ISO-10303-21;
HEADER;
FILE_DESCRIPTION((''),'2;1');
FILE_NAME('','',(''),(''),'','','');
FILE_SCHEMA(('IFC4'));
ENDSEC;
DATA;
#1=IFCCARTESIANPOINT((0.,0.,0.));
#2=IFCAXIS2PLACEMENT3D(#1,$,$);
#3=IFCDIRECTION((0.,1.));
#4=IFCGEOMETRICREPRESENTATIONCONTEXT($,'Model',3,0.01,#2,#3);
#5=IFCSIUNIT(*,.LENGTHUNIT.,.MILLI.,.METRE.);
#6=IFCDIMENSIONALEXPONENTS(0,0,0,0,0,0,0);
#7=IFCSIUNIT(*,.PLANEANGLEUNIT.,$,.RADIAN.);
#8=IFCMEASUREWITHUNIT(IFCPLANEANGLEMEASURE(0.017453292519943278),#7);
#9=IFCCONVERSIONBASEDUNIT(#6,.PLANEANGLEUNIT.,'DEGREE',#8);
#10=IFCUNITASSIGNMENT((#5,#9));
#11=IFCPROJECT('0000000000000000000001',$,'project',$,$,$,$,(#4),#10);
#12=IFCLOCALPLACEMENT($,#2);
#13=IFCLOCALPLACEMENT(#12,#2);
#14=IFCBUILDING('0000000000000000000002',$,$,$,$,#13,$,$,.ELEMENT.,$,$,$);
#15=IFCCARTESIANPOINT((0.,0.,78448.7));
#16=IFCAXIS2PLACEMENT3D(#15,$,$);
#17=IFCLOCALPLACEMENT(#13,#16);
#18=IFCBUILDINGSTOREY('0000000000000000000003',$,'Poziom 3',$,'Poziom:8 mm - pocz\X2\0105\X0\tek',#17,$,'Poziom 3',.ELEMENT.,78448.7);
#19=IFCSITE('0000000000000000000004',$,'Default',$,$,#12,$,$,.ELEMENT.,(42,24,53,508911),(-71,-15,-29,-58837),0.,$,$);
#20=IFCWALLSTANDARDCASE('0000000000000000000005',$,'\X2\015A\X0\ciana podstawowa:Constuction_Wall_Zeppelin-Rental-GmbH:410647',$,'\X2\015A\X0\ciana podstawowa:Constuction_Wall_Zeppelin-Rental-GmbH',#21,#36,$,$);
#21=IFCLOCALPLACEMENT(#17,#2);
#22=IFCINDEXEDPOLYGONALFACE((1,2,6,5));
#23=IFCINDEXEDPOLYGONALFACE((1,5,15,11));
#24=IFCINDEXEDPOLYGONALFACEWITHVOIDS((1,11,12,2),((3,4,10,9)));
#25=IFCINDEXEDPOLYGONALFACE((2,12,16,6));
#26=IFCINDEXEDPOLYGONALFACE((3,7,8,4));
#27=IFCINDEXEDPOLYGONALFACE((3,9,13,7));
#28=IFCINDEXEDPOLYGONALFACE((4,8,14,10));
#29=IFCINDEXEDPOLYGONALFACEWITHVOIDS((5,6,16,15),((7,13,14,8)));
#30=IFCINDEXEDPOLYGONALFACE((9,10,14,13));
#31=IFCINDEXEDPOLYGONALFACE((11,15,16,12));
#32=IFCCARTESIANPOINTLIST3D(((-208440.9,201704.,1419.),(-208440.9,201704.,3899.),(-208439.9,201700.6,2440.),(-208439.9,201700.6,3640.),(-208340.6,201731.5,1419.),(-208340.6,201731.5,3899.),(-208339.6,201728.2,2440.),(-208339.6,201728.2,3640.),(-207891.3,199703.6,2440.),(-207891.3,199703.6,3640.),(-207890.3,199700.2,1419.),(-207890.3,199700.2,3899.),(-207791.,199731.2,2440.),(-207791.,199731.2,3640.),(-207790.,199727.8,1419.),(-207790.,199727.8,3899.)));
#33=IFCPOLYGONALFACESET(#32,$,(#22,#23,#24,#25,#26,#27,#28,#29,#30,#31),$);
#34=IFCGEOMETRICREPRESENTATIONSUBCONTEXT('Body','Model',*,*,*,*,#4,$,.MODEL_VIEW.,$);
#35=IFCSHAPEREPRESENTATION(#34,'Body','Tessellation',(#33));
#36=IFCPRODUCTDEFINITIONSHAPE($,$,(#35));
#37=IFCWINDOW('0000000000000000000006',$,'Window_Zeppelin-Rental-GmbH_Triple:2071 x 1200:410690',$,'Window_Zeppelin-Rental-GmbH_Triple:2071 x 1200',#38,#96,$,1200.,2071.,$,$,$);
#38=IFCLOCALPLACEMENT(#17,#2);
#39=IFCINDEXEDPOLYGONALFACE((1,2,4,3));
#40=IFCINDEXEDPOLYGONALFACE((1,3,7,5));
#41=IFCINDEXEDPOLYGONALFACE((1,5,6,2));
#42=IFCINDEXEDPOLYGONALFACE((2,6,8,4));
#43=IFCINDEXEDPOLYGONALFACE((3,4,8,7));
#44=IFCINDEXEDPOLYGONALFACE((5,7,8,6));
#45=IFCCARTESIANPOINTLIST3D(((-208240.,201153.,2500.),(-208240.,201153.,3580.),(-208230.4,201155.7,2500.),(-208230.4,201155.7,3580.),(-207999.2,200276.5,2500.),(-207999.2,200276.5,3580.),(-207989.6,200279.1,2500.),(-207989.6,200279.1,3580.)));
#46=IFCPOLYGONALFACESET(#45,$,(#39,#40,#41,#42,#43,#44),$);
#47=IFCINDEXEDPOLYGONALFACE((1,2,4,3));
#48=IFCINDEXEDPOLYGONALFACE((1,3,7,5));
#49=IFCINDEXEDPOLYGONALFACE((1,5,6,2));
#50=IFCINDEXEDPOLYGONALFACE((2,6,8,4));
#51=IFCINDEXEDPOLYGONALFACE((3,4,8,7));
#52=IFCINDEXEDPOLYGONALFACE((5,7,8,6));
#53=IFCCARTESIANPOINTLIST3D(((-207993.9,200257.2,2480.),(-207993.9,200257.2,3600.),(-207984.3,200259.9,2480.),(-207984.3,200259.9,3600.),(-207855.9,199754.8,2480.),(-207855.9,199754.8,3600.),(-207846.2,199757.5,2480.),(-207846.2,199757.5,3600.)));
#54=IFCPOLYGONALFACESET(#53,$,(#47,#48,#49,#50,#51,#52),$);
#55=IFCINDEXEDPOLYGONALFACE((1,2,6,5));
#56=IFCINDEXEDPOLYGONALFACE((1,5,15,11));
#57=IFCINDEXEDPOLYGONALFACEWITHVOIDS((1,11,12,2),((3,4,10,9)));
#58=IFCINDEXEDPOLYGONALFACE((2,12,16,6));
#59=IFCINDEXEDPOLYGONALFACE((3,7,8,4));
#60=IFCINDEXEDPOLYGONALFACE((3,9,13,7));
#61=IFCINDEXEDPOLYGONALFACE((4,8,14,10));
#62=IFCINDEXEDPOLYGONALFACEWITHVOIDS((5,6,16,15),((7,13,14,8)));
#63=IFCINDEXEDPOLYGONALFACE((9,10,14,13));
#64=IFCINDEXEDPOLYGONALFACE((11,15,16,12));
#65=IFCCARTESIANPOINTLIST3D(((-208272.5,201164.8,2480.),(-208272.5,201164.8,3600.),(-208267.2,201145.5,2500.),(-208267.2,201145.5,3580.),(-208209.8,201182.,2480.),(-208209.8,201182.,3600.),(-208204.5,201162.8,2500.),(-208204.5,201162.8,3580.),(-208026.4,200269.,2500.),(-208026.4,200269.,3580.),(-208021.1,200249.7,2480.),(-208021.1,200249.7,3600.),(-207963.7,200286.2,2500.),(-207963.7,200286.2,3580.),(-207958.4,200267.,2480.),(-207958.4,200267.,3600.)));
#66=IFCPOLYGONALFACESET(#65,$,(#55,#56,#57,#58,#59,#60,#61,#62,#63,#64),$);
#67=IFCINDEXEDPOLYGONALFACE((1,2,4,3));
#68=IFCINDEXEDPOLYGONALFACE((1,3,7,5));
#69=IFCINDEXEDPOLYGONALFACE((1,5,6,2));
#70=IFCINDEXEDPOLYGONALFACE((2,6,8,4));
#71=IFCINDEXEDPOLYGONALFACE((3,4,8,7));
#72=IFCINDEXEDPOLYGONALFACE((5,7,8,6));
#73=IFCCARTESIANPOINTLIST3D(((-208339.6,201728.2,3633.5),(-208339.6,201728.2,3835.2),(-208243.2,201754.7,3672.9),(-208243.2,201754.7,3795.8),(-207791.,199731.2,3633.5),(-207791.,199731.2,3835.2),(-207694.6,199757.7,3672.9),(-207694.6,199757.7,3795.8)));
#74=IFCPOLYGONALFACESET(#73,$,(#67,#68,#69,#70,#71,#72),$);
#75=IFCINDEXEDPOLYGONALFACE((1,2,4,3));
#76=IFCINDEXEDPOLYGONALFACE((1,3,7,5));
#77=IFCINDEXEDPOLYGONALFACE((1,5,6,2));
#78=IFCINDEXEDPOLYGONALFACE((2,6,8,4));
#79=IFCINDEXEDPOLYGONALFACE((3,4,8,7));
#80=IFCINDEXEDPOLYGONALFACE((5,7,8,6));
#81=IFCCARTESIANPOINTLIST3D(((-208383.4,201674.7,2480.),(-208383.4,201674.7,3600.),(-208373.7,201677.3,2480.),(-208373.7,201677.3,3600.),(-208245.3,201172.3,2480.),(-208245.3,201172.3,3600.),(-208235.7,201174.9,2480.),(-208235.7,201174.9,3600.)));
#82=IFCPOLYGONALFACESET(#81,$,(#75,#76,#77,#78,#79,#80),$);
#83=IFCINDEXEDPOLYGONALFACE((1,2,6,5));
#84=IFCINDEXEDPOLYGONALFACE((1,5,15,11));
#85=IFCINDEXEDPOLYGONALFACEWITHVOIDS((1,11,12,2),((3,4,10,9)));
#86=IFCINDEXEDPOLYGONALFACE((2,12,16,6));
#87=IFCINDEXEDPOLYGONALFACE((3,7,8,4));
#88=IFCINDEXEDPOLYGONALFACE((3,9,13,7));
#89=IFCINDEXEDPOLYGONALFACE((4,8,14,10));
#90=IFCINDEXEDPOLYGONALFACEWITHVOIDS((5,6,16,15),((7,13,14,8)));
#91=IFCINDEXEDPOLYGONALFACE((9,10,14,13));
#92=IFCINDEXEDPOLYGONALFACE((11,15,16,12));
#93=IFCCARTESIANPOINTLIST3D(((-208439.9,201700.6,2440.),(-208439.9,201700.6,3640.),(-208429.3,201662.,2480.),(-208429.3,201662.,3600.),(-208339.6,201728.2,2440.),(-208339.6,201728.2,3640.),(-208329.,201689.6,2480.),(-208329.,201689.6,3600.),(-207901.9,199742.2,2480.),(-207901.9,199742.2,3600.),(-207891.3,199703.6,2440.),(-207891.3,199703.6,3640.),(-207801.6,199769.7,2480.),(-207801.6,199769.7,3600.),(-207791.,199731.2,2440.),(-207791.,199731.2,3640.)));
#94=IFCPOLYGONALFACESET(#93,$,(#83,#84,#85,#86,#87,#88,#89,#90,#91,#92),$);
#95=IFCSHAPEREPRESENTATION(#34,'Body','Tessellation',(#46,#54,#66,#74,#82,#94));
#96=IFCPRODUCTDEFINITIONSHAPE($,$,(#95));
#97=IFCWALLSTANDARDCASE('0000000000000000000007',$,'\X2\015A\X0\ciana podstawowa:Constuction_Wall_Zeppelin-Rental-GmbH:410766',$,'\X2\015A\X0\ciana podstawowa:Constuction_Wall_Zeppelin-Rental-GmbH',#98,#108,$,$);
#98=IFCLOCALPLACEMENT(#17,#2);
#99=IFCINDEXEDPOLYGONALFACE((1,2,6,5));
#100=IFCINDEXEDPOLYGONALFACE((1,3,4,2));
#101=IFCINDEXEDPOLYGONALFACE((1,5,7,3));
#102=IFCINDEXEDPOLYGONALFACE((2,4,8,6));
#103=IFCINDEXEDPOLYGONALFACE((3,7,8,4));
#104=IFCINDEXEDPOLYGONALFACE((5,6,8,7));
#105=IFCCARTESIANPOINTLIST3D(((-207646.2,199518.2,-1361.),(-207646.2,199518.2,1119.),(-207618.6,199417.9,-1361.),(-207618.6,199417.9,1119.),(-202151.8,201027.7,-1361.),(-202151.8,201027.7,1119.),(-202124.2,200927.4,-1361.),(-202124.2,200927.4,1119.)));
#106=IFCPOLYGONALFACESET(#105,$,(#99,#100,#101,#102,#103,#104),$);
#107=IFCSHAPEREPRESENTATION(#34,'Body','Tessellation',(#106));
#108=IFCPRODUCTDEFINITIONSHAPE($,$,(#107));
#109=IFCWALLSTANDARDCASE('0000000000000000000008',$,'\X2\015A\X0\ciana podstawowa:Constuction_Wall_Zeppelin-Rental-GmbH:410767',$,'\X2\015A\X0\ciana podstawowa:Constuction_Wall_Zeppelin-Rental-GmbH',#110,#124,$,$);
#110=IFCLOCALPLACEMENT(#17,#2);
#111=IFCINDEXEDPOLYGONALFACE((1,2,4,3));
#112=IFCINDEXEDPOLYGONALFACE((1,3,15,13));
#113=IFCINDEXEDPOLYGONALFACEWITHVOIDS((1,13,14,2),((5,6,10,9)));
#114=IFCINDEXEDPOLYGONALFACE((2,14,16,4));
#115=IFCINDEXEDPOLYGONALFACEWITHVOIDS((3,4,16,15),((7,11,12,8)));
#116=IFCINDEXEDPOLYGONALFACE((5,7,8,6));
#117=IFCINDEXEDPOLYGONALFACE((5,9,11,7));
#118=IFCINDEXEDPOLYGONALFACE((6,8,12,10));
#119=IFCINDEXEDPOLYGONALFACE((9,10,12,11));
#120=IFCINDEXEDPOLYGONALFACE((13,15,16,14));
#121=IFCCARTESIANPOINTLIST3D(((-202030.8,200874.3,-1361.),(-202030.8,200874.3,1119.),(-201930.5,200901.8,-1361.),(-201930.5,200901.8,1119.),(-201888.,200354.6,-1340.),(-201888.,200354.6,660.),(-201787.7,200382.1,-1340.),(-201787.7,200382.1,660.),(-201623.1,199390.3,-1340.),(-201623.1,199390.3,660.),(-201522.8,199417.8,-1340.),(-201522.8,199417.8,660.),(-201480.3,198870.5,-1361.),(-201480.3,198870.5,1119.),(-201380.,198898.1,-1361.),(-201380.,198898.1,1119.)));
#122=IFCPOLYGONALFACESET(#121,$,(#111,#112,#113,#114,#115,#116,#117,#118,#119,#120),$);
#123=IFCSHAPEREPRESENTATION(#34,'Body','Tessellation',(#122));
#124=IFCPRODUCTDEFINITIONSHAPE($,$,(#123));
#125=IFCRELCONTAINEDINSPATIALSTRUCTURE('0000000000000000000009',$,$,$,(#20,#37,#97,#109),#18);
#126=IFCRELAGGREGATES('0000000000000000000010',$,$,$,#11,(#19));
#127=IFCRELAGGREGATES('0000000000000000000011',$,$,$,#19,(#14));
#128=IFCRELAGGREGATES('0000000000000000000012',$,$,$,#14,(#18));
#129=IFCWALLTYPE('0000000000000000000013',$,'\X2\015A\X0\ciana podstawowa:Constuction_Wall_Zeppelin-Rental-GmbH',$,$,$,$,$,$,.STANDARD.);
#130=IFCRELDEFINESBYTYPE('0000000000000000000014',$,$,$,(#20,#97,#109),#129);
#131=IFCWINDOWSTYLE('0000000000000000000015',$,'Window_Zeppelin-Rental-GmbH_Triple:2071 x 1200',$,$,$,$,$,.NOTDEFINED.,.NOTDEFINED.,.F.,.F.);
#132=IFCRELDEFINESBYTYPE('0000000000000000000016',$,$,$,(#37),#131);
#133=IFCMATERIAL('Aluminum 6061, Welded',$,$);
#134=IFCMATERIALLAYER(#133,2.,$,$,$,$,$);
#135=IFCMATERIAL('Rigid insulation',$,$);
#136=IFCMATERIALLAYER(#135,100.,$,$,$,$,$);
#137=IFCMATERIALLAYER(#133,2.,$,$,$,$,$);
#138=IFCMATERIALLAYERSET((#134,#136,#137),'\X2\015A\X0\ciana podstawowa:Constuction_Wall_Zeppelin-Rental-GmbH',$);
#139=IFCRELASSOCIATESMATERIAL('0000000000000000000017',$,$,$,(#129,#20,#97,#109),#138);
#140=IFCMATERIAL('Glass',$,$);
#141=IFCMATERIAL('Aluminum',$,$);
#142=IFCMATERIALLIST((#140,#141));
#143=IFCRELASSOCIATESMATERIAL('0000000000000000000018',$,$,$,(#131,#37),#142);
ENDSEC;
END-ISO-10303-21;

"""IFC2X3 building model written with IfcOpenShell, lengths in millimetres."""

from ifc_helpers import new_model, entity, si_unit, converted_unit, direction, frame, frame_2d, origin, origin_2d_with_axis, place, context, subcontext, project, spatial, polyline, rectangle, outline, extrude, source, transform, mapped, material, material_list, layer, layer_set, layer_usage, type_object, type_shapes, element, fill, save


model = new_model("IFC2X3")

# Units and contexts
model_context = context("Model", 3, precision=0.01, world=origin(), true_north=direction((0.0, 1.0)))
body_context = subcontext(model_context, "Body", "Model", "MODEL_VIEW")
ifc_project = project(units=[si_unit("LENGTHUNIT", "METRE", prefix="MILLI"), converted_unit("PLANEANGLEUNIT", "DEGREE", entity("IfcPlaneAngleMeasure", 0.017453292519943278), si_unit("PLANEANGLEUNIT", "RADIAN"), dimensions=[0, 0, 0, 0, 0, 0, 0])], contexts=[model_context])

# Site, building, storey
site_placement = place(None, origin())
site = spatial("IfcSite", under=ifc_project, at=site_placement, Name="Default", CompositionType="ELEMENT", RefLatitude=(42, 24, 53, 508911), RefLongitude=(-71, -15, -29, -58837), RefElevation=0.0)
building_placement = place(site_placement, origin())
building = spatial("IfcBuilding", under=site, at=building_placement, CompositionType="ELEMENT")
storey_placement = place(building_placement, frame((0.0, 0.0, 78448.7)))
storey = spatial("IfcBuildingStorey", under=building, at=storey_placement, Name="Poziom 3", ObjectType="Poziom:8 mm - początek", LongName="Poziom 3", CompositionType="ELEMENT", Elevation=78448.7)

# Shared definitions
ifc_material_1 = material(Name="Aluminum 6061, Welded")
ifc_layer_1 = layer(ifc_material_1, 2.0)
ifc_material_2 = material(Name="Rigid insulation")
ifc_layer_2 = layer(ifc_material_2, 100.0)
ifc_layer_3 = layer(ifc_material_1, 2.0)
ifc_layer_set = layer_set([ifc_layer_1, ifc_layer_2, ifc_layer_3], Name="Ściana podstawowa:Constuction_Wall_Zeppelin-Rental-GmbH")
wall_type_1 = type_object("IfcWallType", Name="Ściana podstawowa:Constuction_Wall_Zeppelin-Rental-GmbH", PredefinedType="STANDARD", material=ifc_layer_set)

# Shared definitions
ifc_material_3 = material(Name="Glass")
ifc_material_4 = material(Name="Aluminum")
ifc_material_list = material_list([ifc_material_3, ifc_material_4])
window_style = type_object("IfcWindowStyle", Name="Window_Zeppelin-Rental-GmbH_Triple:2071 x 1200", ConstructionType="NOTDEFINED", OperationType="NOTDEFINED", ParameterTakesPrecedence=False, Sizeable=False, material=ifc_material_list)
shared_shape_1 = source(origin(), body_context, "Body", "SweptSolid", [
    extrude(rectangle(XDim=10.0, YDim=909.0, at=origin_2d_with_axis()), frame((1035.5, 52.7, 60.0), z_axis=(0.0, 0.0, 1.0), x_axis=(0.0, -1.0, 0.0)), (0.0, 0.0, 1.0), 1080.0),
    extrude(rectangle(XDim=521.0, YDim=10.0, at=frame_2d((0.0, 0.0), x_axis=(1.0, 0.0))), frame((300.5, 52.7, 40.0), z_axis=(0.0, 0.0, 1.0), x_axis=(-1.0, 0.0, 0.0)), (0.0, 0.0, 1.0), 1120.0),
    extrude(outline(polyline([(-474.5, -560.0), (474.5, -560.0), (474.5, 560.0), (-474.5, 560.0), (-474.5, -560.0)]), holes=[polyline([(-454.5, 540.0), (454.5, 540.0), (454.5, -540.0), (-454.5, -540.0), (-454.5, 540.0)])]), frame((1035.5, 85.8, 600.0), z_axis=(0.0, -1.0, 0.0), x_axis=(1.0, 0.0, 0.0)), (0.0, 0.0, 1.0), 65.0),
    extrude(outline(polyline([(-24.0, -75.5), (83.5, -75.5), (9.6, 112.1), (-69.0, 38.9), (-24.0, -75.5)])), frame((2071.0, -48.7, 1294.4), z_axis=(-1.0, 0.0, 0.0), x_axis=(0.0, 0.930458, 0.366398)), (0.0, 0.0, 1.0), 2071.0),
    extrude(rectangle(XDim=10.0, YDim=521.0, at=frame_2d((0.0, 0.0), x_axis=(1.0, 0.0))), frame((1770.5, 52.7, 40.0), z_axis=(0.0, 0.0, 1.0), x_axis=(0.0, -1.0, 0.0)), (0.0, 0.0, 1.0), 1120.0),
    extrude(outline(polyline([(-1035.5, -600.0), (1035.5, -600.0), (1035.5, 600.0), (-1035.5, 600.0), (-1035.5, -600.0)]), holes=[polyline([(-995.5, 560.0), (995.5, 560.0), (995.5, -560.0), (-995.5, -560.0), (-995.5, 560.0)])]), frame((1035.5, 105.3, 600.0), z_axis=(0.0, -1.0, 0.0), x_axis=(1.0, 0.0, 0.0)), (0.0, 0.0, 1.0), 104.0),
])
type_shapes(window_style, [shared_shape_1])

# Wall, opening, window
ifc_layer_usage_1 = layer_usage(ifc_layer_set, "AXIS2", "NEGATIVE", 52.0)
wall_1_placement = place(storey_placement, frame((-207840.2, 199714.0, 1419.0), z_axis=(0.0, 0.0, 1.0), x_axis=(-0.264931, 0.964267, 0.0)))
wall_1 = element("IfcWallStandardCase", 1, at=wall_1_placement, inside=storey, type_object=wall_type_1, material=ifc_layer_usage_1, Name="Ściana podstawowa:Constuction_Wall_Zeppelin-Rental-GmbH:410647", ObjectType="Ściana podstawowa:Constuction_Wall_Zeppelin-Rental-GmbH", context=body_context, shape_type="SweptSolid", body=[
    extrude(rectangle(XDim=2078.0, YDim=104.0, at=frame_2d((1039.0, 0.0), x_axis=(-1.0, 0.0))), origin(), (0.0, 0.0, 1.0), 2480.0),
])
opening_1_placement = place(wall_1_placement, frame((3.5, -52.0, 1021.0)))
opening_1 = element("IfcOpeningElement", 2, at=opening_1_placement, cuts=wall_1, ObjectType="Opening", context=body_context, shape_type="SweptSolid", body=[
    extrude(rectangle(XDim=1200.0, YDim=2071.0, at=frame_2d((600.0, 1035.5), x_axis=(1.0, 0.0))), frame((0.0, 0.0, 0.0), z_axis=(0.0, 1.0, 0.0), x_axis=(0.0, 0.0, 1.0)), (0.0, 0.0, 1.0), 104.0),
])
window_1_placement = place(opening_1_placement, frame((0.0, -1.3, 0.0)))
window_1 = element("IfcWindow", 3, at=window_1_placement, inside=storey, type_object=window_style, material=ifc_material_list, Name="Window_Zeppelin-Rental-GmbH_Triple:2071 x 1200:410690", ObjectType="Window_Zeppelin-Rental-GmbH_Triple:2071 x 1200", OverallHeight=1200.0, OverallWidth=2071.0, context=body_context, shape_type="MappedRepresentation", body=[
    mapped(shared_shape_1, transform((0.0, 0.0, 0.0), scale=1.0)),
])
fill(opening_1, window_1)

# Wall
ifc_layer_usage_2 = layer_usage(ifc_layer_set, "AXIS2", "NEGATIVE", 52.0)
wall_2_placement = place(storey_placement, frame((-207632.4, 199468.0, -1361.0), z_axis=(0.0, 0.0, 1.0), x_axis=(0.964267, 0.264931, 0.0)))
element("IfcWallStandardCase", 4, at=wall_2_placement, inside=storey, type_object=wall_type_1, material=ifc_layer_usage_2, Name="Ściana podstawowa:Constuction_Wall_Zeppelin-Rental-GmbH:410766", ObjectType="Ściana podstawowa:Constuction_Wall_Zeppelin-Rental-GmbH", context=body_context, shape_type="SweptSolid", body=[
    extrude(rectangle(XDim=5698.0, YDim=104.0, at=frame_2d((2849.0, 0.0), x_axis=(-1.0, 0.0))), origin(), (0.0, 0.0, 1.0), 2480.0),
])

# Wall, opening
ifc_layer_usage_3 = layer_usage(ifc_layer_set, "AXIS2", "NEGATIVE", 52.0)
wall_3_placement = place(storey_placement, frame((-201980.6, 200888.1, -1361.0), z_axis=(0.0, 0.0, 1.0), x_axis=(0.264931, -0.964267, 0.0)))
wall_3 = element("IfcWallStandardCase", 5, at=wall_3_placement, inside=storey, type_object=wall_type_1, material=ifc_layer_usage_3, Name="Ściana podstawowa:Constuction_Wall_Zeppelin-Rental-GmbH:410767", ObjectType="Ściana podstawowa:Constuction_Wall_Zeppelin-Rental-GmbH", context=body_context, shape_type="SweptSolid", body=[
    extrude(rectangle(XDim=2078.0, YDim=104.0, at=frame_2d((1039.0, 0.0), x_axis=(-1.0, 0.0))), origin(), (0.0, 0.0, 1.0), 2480.0),
])
opening_2_placement = place(wall_3_placement, frame((539.0, -52.0, 21.0)))
element("IfcOpeningElement", 6, at=opening_2_placement, cuts=wall_3, ObjectType="Opening", context=body_context, shape_type="SweptSolid", body=[
    extrude(rectangle(XDim=2000.0, YDim=1000.0, at=frame_2d((1000.0, 500.0), x_axis=(1.0, 0.0))), frame((0.0, 0.0, 0.0), z_axis=(0.0, 1.0, 0.0), x_axis=(0.0, 0.0, 1.0)), (0.0, 0.0, 1.0), 104.0),
])

save(model, "model.ifc")
